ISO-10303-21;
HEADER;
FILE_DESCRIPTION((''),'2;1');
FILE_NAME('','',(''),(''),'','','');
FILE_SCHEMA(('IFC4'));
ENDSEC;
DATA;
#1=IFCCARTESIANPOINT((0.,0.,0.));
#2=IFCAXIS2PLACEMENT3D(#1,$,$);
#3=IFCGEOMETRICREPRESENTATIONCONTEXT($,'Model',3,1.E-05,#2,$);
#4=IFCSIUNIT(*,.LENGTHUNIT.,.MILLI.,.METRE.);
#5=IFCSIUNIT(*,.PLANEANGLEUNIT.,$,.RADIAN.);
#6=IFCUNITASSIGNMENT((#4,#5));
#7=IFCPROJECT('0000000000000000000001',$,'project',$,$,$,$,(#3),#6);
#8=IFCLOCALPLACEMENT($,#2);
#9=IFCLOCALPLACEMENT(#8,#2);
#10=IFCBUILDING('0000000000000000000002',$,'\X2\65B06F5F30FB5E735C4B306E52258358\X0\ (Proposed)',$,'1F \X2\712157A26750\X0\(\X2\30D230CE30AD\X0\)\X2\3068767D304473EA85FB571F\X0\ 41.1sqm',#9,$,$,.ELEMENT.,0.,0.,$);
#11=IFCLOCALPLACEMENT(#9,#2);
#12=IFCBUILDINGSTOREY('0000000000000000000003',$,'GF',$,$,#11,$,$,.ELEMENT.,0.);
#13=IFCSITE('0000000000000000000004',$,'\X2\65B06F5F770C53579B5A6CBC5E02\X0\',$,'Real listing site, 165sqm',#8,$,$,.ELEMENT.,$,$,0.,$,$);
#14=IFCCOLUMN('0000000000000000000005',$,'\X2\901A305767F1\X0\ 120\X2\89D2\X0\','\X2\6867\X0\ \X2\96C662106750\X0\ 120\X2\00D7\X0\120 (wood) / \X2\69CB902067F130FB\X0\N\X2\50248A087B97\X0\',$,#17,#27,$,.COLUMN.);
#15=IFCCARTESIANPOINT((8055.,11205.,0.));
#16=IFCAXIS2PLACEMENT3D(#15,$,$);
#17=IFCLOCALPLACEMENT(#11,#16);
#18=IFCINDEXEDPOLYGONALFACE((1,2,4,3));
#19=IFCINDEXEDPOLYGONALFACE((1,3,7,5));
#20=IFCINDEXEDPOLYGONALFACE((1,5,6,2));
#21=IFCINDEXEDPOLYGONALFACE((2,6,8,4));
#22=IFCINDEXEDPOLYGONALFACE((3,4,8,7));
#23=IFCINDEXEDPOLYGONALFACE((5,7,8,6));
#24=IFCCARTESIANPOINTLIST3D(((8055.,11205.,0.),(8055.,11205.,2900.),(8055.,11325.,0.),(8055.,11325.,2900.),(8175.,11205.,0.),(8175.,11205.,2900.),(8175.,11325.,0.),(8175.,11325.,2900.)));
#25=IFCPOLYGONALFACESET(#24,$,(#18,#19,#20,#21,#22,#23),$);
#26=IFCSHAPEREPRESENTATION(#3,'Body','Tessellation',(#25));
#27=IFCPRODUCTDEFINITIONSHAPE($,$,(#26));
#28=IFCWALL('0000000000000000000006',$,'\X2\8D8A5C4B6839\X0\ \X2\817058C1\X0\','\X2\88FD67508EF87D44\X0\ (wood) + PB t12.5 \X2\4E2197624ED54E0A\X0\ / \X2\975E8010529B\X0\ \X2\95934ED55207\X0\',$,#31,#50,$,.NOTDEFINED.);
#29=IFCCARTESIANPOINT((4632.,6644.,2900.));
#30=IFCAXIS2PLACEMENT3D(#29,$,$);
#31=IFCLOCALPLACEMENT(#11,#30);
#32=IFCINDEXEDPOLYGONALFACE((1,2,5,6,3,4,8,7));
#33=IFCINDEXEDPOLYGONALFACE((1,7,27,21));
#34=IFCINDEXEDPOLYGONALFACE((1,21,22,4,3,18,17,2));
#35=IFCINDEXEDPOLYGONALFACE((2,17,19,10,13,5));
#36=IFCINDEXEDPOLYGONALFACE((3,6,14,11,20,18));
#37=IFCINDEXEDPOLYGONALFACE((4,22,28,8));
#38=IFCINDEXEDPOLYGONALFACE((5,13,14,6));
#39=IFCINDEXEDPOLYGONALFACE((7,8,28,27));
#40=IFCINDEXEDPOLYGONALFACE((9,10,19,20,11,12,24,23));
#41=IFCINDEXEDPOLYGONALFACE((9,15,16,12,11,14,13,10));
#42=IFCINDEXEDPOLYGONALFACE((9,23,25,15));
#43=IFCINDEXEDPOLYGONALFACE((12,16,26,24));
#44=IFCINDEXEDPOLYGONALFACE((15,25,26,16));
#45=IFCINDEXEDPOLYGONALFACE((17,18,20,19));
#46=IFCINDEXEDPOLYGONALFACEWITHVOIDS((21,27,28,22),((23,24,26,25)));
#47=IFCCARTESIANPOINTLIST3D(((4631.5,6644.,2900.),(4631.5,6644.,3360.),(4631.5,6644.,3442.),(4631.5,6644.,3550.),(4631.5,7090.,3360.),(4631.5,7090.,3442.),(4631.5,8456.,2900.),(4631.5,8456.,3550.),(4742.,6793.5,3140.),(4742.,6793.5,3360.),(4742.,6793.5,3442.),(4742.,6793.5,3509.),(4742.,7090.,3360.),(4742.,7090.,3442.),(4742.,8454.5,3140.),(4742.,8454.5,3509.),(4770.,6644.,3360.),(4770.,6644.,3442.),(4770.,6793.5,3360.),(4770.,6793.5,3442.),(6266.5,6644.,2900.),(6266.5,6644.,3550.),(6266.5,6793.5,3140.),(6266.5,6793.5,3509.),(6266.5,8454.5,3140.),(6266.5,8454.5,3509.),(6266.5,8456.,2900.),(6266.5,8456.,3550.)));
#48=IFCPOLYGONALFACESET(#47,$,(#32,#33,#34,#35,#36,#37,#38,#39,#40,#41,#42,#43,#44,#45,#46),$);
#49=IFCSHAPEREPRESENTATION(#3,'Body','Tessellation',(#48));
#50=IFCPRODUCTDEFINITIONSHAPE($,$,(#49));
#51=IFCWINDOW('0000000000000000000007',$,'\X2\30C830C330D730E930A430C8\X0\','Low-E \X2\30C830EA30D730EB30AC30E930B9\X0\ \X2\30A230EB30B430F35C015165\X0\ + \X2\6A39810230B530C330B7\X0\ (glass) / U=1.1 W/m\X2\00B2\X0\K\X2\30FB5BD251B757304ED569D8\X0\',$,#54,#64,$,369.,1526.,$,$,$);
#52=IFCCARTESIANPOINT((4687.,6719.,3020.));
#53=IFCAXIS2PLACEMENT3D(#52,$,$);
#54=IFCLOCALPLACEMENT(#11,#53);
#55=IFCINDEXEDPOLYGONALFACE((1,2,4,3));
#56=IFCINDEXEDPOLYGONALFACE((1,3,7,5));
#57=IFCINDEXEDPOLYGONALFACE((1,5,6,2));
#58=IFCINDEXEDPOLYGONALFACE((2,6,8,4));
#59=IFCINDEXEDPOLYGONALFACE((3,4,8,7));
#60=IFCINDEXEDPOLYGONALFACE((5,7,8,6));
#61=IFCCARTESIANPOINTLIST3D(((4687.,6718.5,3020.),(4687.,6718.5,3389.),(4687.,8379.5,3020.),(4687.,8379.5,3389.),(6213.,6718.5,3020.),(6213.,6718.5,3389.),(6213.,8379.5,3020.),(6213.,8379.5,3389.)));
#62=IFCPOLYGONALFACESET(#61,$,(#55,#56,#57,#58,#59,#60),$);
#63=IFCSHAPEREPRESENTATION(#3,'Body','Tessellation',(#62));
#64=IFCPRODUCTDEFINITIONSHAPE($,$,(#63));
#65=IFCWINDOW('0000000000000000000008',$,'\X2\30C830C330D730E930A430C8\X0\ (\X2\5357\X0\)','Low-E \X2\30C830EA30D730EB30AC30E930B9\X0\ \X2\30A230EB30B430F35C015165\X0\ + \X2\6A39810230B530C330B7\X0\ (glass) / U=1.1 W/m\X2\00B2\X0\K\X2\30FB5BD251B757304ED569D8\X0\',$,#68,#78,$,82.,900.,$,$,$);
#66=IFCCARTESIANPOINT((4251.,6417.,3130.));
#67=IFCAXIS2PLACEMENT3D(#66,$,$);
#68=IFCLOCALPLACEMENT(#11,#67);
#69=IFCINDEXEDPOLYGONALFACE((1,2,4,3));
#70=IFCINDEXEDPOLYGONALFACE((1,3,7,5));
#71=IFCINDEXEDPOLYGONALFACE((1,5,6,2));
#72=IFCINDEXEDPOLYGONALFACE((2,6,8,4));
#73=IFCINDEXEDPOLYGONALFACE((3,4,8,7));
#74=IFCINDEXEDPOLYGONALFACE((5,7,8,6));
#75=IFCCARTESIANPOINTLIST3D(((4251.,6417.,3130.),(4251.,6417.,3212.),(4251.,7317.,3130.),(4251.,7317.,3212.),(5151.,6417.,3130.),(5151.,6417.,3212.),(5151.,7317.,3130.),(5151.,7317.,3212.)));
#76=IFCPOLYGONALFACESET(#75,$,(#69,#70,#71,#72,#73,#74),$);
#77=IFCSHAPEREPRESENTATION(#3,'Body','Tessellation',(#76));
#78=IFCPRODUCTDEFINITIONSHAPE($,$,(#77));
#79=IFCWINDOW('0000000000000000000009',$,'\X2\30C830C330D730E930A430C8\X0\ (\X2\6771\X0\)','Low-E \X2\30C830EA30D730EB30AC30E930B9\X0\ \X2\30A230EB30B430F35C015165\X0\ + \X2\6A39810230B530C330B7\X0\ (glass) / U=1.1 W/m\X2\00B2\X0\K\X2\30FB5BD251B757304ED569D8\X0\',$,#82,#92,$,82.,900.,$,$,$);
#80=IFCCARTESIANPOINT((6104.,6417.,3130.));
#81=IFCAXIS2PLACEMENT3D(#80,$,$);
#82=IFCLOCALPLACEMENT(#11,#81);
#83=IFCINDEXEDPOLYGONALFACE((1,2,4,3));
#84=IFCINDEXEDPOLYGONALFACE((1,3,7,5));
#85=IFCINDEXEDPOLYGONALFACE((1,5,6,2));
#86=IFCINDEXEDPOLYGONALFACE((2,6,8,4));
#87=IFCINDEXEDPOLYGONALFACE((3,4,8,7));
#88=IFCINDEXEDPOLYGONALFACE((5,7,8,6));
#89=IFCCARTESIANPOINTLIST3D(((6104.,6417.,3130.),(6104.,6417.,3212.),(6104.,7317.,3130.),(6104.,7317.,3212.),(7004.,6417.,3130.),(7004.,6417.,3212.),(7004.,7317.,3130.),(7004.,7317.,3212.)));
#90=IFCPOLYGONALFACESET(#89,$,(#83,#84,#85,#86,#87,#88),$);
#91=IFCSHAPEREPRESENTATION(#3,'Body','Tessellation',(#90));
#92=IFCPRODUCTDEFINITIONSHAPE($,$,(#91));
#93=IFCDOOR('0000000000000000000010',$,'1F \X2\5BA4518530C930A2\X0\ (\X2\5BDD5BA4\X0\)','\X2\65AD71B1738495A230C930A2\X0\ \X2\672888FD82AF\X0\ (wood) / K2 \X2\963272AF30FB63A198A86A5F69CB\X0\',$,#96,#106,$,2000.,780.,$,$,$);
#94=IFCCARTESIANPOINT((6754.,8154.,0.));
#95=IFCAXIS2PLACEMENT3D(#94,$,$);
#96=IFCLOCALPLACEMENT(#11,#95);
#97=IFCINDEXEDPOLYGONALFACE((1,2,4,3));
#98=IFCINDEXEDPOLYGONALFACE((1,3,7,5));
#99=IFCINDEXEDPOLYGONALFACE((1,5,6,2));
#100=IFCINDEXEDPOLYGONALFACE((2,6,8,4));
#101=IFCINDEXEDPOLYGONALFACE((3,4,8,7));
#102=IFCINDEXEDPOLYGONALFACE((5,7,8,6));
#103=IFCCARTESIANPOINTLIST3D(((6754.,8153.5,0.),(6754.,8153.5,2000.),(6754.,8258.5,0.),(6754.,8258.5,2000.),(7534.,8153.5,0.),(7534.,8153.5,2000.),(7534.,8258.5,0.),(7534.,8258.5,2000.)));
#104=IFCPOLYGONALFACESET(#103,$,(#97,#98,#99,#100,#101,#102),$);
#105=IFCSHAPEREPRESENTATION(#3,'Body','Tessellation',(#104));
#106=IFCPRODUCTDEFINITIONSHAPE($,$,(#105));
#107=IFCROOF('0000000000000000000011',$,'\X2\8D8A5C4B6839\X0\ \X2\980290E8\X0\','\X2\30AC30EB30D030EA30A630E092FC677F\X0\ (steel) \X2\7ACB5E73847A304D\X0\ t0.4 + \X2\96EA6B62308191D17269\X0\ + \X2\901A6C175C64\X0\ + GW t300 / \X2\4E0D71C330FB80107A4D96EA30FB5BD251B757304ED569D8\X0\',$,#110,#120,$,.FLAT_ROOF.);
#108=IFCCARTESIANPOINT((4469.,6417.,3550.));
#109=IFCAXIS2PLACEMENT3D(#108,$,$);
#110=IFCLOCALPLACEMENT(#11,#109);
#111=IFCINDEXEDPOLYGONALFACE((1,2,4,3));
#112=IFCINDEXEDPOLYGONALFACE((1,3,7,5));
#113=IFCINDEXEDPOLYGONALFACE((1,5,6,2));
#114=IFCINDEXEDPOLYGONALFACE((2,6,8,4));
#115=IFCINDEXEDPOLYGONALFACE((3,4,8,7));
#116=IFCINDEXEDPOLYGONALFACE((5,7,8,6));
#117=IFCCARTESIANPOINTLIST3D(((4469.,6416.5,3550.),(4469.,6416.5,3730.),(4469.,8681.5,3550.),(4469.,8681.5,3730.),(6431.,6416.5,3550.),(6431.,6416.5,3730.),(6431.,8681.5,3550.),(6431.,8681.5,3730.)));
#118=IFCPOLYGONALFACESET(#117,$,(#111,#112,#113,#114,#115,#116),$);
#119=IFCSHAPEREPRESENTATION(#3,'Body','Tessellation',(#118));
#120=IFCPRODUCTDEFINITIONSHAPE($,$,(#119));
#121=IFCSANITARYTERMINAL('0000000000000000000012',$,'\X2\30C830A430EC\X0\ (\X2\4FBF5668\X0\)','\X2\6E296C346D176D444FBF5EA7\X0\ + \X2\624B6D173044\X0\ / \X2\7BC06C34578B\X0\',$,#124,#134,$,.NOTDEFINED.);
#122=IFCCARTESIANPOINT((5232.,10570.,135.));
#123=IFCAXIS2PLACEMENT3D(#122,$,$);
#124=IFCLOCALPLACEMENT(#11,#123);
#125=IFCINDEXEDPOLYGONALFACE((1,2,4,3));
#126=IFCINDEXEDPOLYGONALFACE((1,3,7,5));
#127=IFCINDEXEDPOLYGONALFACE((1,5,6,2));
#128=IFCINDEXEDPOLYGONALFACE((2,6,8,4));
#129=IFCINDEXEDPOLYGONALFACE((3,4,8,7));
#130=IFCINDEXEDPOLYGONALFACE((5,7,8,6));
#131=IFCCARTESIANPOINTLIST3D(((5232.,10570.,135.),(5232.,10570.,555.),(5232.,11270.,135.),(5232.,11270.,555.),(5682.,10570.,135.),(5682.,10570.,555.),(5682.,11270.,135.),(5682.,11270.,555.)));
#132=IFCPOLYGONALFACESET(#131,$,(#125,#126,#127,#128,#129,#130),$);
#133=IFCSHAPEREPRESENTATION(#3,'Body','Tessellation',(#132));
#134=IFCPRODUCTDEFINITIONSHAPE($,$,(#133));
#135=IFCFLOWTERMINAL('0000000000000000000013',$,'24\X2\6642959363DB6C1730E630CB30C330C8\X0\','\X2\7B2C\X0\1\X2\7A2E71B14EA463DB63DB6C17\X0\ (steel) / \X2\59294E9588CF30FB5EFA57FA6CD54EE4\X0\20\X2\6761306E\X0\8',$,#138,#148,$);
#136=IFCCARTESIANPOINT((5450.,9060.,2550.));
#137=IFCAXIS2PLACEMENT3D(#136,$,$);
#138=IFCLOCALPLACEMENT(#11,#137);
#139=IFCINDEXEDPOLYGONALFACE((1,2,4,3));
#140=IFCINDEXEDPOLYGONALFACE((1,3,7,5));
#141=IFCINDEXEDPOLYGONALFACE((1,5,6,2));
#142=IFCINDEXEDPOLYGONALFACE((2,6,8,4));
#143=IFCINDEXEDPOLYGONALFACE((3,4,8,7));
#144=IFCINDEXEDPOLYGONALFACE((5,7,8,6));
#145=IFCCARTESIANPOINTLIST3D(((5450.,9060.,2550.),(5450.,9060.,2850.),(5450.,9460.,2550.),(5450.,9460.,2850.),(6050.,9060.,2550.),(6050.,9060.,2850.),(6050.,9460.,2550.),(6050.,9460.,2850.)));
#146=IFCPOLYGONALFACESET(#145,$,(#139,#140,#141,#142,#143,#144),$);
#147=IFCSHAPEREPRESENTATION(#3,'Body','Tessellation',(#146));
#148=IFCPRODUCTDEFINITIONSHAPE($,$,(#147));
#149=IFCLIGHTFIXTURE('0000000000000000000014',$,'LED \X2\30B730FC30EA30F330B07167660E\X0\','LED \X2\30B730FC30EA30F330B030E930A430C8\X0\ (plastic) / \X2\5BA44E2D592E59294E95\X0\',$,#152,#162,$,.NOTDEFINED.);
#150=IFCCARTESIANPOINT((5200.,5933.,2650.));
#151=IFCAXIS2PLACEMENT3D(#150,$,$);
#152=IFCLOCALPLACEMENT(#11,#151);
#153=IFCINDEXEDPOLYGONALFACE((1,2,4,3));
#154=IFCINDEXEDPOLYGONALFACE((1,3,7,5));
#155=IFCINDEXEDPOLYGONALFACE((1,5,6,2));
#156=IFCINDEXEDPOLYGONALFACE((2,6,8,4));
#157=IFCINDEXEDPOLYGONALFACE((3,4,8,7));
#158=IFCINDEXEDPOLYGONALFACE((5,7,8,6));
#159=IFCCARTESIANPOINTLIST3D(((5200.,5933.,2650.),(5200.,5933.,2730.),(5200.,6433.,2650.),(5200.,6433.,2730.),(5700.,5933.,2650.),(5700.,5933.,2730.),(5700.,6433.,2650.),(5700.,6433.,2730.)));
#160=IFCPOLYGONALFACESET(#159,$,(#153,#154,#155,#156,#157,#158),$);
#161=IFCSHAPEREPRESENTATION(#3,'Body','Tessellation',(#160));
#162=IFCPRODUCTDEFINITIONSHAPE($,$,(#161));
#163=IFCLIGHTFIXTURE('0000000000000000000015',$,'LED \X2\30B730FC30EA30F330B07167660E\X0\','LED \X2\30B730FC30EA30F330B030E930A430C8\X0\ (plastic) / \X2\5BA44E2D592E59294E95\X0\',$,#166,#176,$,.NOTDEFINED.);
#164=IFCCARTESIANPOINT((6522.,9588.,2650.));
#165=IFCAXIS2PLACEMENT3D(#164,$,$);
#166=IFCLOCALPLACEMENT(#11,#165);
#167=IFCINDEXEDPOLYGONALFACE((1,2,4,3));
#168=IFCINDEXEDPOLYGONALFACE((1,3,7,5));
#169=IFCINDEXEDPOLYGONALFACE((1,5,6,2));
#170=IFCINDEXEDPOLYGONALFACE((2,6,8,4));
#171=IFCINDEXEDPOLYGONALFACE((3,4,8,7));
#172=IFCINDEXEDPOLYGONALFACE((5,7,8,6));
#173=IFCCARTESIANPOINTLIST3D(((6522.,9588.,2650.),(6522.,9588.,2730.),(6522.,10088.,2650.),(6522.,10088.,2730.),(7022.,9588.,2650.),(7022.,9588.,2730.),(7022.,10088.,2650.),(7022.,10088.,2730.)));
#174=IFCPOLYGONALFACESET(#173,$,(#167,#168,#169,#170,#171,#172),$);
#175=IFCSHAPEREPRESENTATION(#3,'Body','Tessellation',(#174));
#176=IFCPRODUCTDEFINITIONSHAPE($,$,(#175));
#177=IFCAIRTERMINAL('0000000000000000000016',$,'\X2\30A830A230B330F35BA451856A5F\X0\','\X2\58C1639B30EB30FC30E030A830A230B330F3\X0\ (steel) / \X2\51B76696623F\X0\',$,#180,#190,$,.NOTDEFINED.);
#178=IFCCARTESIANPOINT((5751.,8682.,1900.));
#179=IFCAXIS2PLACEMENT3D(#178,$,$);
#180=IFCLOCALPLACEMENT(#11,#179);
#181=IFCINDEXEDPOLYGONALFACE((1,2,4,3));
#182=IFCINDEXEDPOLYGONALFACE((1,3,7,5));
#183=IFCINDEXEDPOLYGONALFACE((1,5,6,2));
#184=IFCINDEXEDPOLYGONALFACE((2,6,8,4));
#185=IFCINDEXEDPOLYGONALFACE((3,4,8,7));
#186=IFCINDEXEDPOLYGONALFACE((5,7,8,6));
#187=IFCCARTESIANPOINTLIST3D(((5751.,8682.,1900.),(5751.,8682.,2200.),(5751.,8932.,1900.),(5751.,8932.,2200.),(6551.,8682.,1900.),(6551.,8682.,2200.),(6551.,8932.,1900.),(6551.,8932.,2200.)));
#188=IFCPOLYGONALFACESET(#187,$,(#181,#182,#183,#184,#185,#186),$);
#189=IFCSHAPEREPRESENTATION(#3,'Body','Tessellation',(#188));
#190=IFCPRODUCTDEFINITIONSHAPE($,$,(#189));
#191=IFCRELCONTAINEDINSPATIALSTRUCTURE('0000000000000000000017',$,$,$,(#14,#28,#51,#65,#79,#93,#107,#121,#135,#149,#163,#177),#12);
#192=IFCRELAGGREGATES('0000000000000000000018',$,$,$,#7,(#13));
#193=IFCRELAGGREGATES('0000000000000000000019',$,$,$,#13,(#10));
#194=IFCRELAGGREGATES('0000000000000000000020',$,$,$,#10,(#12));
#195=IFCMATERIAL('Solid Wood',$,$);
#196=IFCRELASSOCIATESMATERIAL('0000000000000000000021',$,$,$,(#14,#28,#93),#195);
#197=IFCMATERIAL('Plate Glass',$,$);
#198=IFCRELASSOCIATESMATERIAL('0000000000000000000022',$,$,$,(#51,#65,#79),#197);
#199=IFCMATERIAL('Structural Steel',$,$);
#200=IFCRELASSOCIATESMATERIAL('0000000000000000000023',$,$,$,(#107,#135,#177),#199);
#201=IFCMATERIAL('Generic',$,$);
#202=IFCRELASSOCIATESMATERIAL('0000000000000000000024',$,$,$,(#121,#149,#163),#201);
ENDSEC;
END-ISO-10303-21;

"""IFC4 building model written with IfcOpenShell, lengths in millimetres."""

from ifc_helpers import new_model, si_unit, frame, frame_2d, origin, place, context, project, spatial, rectangle, extrude, material, element, fill, save


model = new_model("IFC4")

# Units and contexts
model_context = context("Model", 3, precision=1e-05, world=origin())
ifc_project = project(units=[si_unit("LENGTHUNIT", "METRE", prefix="MILLI"), si_unit("PLANEANGLEUNIT", "RADIAN")], contexts=[model_context])

# Site, building, storey
site_placement = place(None, origin())
site = spatial("IfcSite", under=ifc_project, at=site_placement, Name="新潟県南魚沼市", ObjectType="Real listing site, 165sqm", CompositionType="ELEMENT", RefElevation=0.0)
building_placement = place(site_placement, origin())
building = spatial("IfcBuilding", under=site, at=building_placement, Name="新潟・平屋の別荘 (Proposed)", ObjectType="1F 無垢材(ヒノキ)と白い珪藻土 41.1sqm", CompositionType="ELEMENT", ElevationOfRefHeight=0.0, ElevationOfTerrain=0.0)
storey_placement = place(building_placement, origin())
storey = spatial("IfcBuildingStorey", under=building, at=storey_placement, Name="GF", CompositionType="ELEMENT", Elevation=0.0)

# Column
ifc_material_1 = material(Name="Solid Wood")
column_1_placement = place(storey_placement, frame((8055.0, 11205.0, 0.0)))
element("IfcColumn", 1, at=column_1_placement, inside=storey, material=ifc_material_1, Name="通し柱 120角", Description="桧 集成材 120×120 (wood) / 構造柱・N値計算", PredefinedType="COLUMN", context=model_context, shape_type="SweptSolid", body=[
    extrude(rectangle(XDim=120.0, YDim=120.0, at=frame_2d((60.0, 60.0))), frame((8055.0, 11205.0, 0.0)), (0.0, 0.0, 1.0), 2900.0),
])

# Wall, openings, windows
wall_1_placement = place(storey_placement, frame((4632.0, 6644.0, 2900.0)))
wall_1 = element("IfcWall", 2, at=wall_1_placement, inside=storey, material=ifc_material_1, Name="越屋根 腰壁", Description="製材軸組 (wood) + PB t12.5 両面仕上 / 非耐力 間仕切", PredefinedType="NOTDEFINED", context=model_context, shape_type="SweptSolid", body=[
    extrude(rectangle(XDim=1635.0, YDim=1812.0, at=frame_2d((817.0, 906.0))), frame((4632.0, 6644.0, 2900.0)), (0.0, 0.0, 1.0), 650.0),
])
opening_1_placement = place(storey_placement, frame((4687.0, 6719.0, 3020.0)))
opening_1 = element("IfcOpeningElement", 3, at=opening_1_placement, cuts=wall_1, PredefinedType="NOTDEFINED", context=model_context, shape_type="SweptSolid", body=[
    extrude(rectangle(XDim=1526.0, YDim=1661.0, at=frame_2d((763.0, 830.0))), frame((4687.0, 6719.0, 3020.0)), (0.0, 0.0, 1.0), 369.0),
])
opening_2_placement = place(storey_placement, frame((4251.0, 6417.0, 3130.0)))
opening_2 = element("IfcOpeningElement", 4, at=opening_2_placement, cuts=wall_1, PredefinedType="NOTDEFINED", context=model_context, shape_type="SweptSolid", body=[
    extrude(rectangle(XDim=900.0, YDim=900.0, at=frame_2d((450.0, 450.0))), frame((4251.0, 6417.0, 3130.0)), (0.0, 0.0, 1.0), 82.0),
])
opening_3_placement = place(storey_placement, frame((6104.0, 6417.0, 3130.0)))
opening_3 = element("IfcOpeningElement", 5, at=opening_3_placement, cuts=wall_1, PredefinedType="NOTDEFINED", context=model_context, shape_type="SweptSolid", body=[
    extrude(rectangle(XDim=900.0, YDim=900.0, at=frame_2d((450.0, 450.0))), frame((6104.0, 6417.0, 3130.0)), (0.0, 0.0, 1.0), 82.0),
])
ifc_material_2 = material(Name="Plate Glass")
window_1_placement = place(storey_placement, frame((4687.0, 6719.0, 3020.0)))
window_1 = element("IfcWindow", 6, at=window_1_placement, inside=storey, material=ifc_material_2, Name="トップライト", Description="Low-E トリプルガラス アルゴン封入 + 樹脂サッシ (glass) / U=1.1 W/m²K・寒冷地仕様", OverallHeight=369.0, OverallWidth=1526.0, context=model_context, shape_type="SweptSolid", body=[
    extrude(rectangle(XDim=1526.0, YDim=1661.0, at=frame_2d((763.0, 830.0))), frame((4687.0, 6719.0, 3020.0)), (0.0, 0.0, 1.0), 369.0),
])
fill(opening_1, window_1)
window_2_placement = place(storey_placement, frame((4251.0, 6417.0, 3130.0)))
window_2 = element("IfcWindow", 7, at=window_2_placement, inside=storey, material=ifc_material_2, Name="トップライト (南)", Description="Low-E トリプルガラス アルゴン封入 + 樹脂サッシ (glass) / U=1.1 W/m²K・寒冷地仕様", OverallHeight=82.0, OverallWidth=900.0, context=model_context, shape_type="SweptSolid", body=[
    extrude(rectangle(XDim=900.0, YDim=900.0, at=frame_2d((450.0, 450.0))), frame((4251.0, 6417.0, 3130.0)), (0.0, 0.0, 1.0), 82.0),
])
fill(opening_2, window_2)
window_3_placement = place(storey_placement, frame((6104.0, 6417.0, 3130.0)))
window_3 = element("IfcWindow", 8, at=window_3_placement, inside=storey, material=ifc_material_2, Name="トップライト (東)", Description="Low-E トリプルガラス アルゴン封入 + 樹脂サッシ (glass) / U=1.1 W/m²K・寒冷地仕様", OverallHeight=82.0, OverallWidth=900.0, context=model_context, shape_type="SweptSolid", body=[
    extrude(rectangle(XDim=900.0, YDim=900.0, at=frame_2d((450.0, 450.0))), frame((6104.0, 6417.0, 3130.0)), (0.0, 0.0, 1.0), 82.0),
])
fill(opening_3, window_3)

# Door
door_placement = place(storey_placement, frame((6754.0, 8154.0, 0.0)))
element("IfcDoor", 9, at=door_placement, inside=storey, material=ifc_material_1, Name="1F 室内ドア (寝室)", Description="断熱玄関ドア 木製芯 (wood) / K2 防犯・採風機構", OverallHeight=2000.0, OverallWidth=780.0, context=model_context, shape_type="SweptSolid", body=[
    extrude(rectangle(XDim=780.0, YDim=105.0, at=frame_2d((390.0, 52.0))), frame((6754.0, 8154.0, 0.0)), (0.0, 0.0, 1.0), 2000.0),
])

# Roof
ifc_material_3 = material(Name="Structural Steel")
roof_placement = place(storey_placement, frame((4469.0, 6417.0, 3550.0)))
element("IfcRoof", 10, at=roof_placement, inside=storey, material=ifc_material_3, Name="越屋根 頂部", Description="ガルバリウム鋼板 (steel) 立平葺き t0.4 + 雪止め金物 + 通気層 + GW t300 / 不燃・耐積雪・寒冷地仕様", PredefinedType="FLAT_ROOF", context=model_context, shape_type="SweptSolid", body=[
    extrude(rectangle(XDim=1962.0, YDim=2265.0, at=frame_2d((981.0, 1132.0))), frame((4469.0, 6417.0, 3550.0)), (0.0, 0.0, 1.0), 180.0),
])

# Sanitary terminal
ifc_material_4 = material(Name="Generic")
sanitary_terminal_placement = place(storey_placement, frame((5232.0, 10570.0, 135.0)))
element("IfcSanitaryTerminal", 11, at=sanitary_terminal_placement, inside=storey, material=ifc_material_4, Name="トイレ (便器)", Description="温水洗浄便座 + 手洗い / 節水型", PredefinedType="NOTDEFINED", context=model_context, shape_type="SweptSolid", body=[
    extrude(rectangle(XDim=450.0, YDim=700.0, at=frame_2d((225.0, 350.0))), frame((5232.0, 10570.0, 135.0)), (0.0, 0.0, 1.0), 420.0),
])

# Flow terminal
flow_terminal_placement = place(storey_placement, frame((5450.0, 9060.0, 2550.0)))
element("IfcFlowTerminal", 12, at=flow_terminal_placement, inside=storey, material=ifc_material_3, Name="24時間換気ユニット", Description="第1種熱交換換気 (steel) / 天井裏・建基法令20条の8", context=model_context, shape_type="SweptSolid", body=[
    extrude(rectangle(XDim=600.0, YDim=400.0, at=frame_2d((300.0, 200.0))), frame((5450.0, 9060.0, 2550.0)), (0.0, 0.0, 1.0), 300.0),
])

# Light fixtures
light_fixture_1_placement = place(storey_placement, frame((5200.0, 5933.0, 2650.0)))
element("IfcLightFixture", 13, at=light_fixture_1_placement, inside=storey, material=ifc_material_4, Name="LED シーリング照明", Description="LED シーリングライト (plastic) / 室中央天井", PredefinedType="NOTDEFINED", context=model_context, shape_type="SweptSolid", body=[
    extrude(rectangle(XDim=500.0, YDim=500.0, at=frame_2d((250.0, 250.0))), frame((5200.0, 5933.0, 2650.0)), (0.0, 0.0, 1.0), 80.0),
])
light_fixture_2_placement = place(storey_placement, frame((6522.0, 9588.0, 2650.0)))
element("IfcLightFixture", 14, at=light_fixture_2_placement, inside=storey, material=ifc_material_4, Name="LED シーリング照明", Description="LED シーリングライト (plastic) / 室中央天井", PredefinedType="NOTDEFINED", context=model_context, shape_type="SweptSolid", body=[
    extrude(rectangle(XDim=500.0, YDim=500.0, at=frame_2d((250.0, 250.0))), frame((6522.0, 9588.0, 2650.0)), (0.0, 0.0, 1.0), 80.0),
])

# Air terminal
air_terminal_placement = place(storey_placement, frame((5751.0, 8682.0, 1900.0)))
element("IfcAirTerminal", 15, at=air_terminal_placement, inside=storey, material=ifc_material_3, Name="エアコン室内機", Description="壁掛ルームエアコン (steel) / 冷暖房", PredefinedType="NOTDEFINED", context=model_context, shape_type="SweptSolid", body=[
    extrude(rectangle(XDim=800.0, YDim=250.0, at=frame_2d((400.0, 125.0))), frame((5751.0, 8682.0, 1900.0)), (0.0, 0.0, 1.0), 300.0),
])

save(model, "model.ifc")
